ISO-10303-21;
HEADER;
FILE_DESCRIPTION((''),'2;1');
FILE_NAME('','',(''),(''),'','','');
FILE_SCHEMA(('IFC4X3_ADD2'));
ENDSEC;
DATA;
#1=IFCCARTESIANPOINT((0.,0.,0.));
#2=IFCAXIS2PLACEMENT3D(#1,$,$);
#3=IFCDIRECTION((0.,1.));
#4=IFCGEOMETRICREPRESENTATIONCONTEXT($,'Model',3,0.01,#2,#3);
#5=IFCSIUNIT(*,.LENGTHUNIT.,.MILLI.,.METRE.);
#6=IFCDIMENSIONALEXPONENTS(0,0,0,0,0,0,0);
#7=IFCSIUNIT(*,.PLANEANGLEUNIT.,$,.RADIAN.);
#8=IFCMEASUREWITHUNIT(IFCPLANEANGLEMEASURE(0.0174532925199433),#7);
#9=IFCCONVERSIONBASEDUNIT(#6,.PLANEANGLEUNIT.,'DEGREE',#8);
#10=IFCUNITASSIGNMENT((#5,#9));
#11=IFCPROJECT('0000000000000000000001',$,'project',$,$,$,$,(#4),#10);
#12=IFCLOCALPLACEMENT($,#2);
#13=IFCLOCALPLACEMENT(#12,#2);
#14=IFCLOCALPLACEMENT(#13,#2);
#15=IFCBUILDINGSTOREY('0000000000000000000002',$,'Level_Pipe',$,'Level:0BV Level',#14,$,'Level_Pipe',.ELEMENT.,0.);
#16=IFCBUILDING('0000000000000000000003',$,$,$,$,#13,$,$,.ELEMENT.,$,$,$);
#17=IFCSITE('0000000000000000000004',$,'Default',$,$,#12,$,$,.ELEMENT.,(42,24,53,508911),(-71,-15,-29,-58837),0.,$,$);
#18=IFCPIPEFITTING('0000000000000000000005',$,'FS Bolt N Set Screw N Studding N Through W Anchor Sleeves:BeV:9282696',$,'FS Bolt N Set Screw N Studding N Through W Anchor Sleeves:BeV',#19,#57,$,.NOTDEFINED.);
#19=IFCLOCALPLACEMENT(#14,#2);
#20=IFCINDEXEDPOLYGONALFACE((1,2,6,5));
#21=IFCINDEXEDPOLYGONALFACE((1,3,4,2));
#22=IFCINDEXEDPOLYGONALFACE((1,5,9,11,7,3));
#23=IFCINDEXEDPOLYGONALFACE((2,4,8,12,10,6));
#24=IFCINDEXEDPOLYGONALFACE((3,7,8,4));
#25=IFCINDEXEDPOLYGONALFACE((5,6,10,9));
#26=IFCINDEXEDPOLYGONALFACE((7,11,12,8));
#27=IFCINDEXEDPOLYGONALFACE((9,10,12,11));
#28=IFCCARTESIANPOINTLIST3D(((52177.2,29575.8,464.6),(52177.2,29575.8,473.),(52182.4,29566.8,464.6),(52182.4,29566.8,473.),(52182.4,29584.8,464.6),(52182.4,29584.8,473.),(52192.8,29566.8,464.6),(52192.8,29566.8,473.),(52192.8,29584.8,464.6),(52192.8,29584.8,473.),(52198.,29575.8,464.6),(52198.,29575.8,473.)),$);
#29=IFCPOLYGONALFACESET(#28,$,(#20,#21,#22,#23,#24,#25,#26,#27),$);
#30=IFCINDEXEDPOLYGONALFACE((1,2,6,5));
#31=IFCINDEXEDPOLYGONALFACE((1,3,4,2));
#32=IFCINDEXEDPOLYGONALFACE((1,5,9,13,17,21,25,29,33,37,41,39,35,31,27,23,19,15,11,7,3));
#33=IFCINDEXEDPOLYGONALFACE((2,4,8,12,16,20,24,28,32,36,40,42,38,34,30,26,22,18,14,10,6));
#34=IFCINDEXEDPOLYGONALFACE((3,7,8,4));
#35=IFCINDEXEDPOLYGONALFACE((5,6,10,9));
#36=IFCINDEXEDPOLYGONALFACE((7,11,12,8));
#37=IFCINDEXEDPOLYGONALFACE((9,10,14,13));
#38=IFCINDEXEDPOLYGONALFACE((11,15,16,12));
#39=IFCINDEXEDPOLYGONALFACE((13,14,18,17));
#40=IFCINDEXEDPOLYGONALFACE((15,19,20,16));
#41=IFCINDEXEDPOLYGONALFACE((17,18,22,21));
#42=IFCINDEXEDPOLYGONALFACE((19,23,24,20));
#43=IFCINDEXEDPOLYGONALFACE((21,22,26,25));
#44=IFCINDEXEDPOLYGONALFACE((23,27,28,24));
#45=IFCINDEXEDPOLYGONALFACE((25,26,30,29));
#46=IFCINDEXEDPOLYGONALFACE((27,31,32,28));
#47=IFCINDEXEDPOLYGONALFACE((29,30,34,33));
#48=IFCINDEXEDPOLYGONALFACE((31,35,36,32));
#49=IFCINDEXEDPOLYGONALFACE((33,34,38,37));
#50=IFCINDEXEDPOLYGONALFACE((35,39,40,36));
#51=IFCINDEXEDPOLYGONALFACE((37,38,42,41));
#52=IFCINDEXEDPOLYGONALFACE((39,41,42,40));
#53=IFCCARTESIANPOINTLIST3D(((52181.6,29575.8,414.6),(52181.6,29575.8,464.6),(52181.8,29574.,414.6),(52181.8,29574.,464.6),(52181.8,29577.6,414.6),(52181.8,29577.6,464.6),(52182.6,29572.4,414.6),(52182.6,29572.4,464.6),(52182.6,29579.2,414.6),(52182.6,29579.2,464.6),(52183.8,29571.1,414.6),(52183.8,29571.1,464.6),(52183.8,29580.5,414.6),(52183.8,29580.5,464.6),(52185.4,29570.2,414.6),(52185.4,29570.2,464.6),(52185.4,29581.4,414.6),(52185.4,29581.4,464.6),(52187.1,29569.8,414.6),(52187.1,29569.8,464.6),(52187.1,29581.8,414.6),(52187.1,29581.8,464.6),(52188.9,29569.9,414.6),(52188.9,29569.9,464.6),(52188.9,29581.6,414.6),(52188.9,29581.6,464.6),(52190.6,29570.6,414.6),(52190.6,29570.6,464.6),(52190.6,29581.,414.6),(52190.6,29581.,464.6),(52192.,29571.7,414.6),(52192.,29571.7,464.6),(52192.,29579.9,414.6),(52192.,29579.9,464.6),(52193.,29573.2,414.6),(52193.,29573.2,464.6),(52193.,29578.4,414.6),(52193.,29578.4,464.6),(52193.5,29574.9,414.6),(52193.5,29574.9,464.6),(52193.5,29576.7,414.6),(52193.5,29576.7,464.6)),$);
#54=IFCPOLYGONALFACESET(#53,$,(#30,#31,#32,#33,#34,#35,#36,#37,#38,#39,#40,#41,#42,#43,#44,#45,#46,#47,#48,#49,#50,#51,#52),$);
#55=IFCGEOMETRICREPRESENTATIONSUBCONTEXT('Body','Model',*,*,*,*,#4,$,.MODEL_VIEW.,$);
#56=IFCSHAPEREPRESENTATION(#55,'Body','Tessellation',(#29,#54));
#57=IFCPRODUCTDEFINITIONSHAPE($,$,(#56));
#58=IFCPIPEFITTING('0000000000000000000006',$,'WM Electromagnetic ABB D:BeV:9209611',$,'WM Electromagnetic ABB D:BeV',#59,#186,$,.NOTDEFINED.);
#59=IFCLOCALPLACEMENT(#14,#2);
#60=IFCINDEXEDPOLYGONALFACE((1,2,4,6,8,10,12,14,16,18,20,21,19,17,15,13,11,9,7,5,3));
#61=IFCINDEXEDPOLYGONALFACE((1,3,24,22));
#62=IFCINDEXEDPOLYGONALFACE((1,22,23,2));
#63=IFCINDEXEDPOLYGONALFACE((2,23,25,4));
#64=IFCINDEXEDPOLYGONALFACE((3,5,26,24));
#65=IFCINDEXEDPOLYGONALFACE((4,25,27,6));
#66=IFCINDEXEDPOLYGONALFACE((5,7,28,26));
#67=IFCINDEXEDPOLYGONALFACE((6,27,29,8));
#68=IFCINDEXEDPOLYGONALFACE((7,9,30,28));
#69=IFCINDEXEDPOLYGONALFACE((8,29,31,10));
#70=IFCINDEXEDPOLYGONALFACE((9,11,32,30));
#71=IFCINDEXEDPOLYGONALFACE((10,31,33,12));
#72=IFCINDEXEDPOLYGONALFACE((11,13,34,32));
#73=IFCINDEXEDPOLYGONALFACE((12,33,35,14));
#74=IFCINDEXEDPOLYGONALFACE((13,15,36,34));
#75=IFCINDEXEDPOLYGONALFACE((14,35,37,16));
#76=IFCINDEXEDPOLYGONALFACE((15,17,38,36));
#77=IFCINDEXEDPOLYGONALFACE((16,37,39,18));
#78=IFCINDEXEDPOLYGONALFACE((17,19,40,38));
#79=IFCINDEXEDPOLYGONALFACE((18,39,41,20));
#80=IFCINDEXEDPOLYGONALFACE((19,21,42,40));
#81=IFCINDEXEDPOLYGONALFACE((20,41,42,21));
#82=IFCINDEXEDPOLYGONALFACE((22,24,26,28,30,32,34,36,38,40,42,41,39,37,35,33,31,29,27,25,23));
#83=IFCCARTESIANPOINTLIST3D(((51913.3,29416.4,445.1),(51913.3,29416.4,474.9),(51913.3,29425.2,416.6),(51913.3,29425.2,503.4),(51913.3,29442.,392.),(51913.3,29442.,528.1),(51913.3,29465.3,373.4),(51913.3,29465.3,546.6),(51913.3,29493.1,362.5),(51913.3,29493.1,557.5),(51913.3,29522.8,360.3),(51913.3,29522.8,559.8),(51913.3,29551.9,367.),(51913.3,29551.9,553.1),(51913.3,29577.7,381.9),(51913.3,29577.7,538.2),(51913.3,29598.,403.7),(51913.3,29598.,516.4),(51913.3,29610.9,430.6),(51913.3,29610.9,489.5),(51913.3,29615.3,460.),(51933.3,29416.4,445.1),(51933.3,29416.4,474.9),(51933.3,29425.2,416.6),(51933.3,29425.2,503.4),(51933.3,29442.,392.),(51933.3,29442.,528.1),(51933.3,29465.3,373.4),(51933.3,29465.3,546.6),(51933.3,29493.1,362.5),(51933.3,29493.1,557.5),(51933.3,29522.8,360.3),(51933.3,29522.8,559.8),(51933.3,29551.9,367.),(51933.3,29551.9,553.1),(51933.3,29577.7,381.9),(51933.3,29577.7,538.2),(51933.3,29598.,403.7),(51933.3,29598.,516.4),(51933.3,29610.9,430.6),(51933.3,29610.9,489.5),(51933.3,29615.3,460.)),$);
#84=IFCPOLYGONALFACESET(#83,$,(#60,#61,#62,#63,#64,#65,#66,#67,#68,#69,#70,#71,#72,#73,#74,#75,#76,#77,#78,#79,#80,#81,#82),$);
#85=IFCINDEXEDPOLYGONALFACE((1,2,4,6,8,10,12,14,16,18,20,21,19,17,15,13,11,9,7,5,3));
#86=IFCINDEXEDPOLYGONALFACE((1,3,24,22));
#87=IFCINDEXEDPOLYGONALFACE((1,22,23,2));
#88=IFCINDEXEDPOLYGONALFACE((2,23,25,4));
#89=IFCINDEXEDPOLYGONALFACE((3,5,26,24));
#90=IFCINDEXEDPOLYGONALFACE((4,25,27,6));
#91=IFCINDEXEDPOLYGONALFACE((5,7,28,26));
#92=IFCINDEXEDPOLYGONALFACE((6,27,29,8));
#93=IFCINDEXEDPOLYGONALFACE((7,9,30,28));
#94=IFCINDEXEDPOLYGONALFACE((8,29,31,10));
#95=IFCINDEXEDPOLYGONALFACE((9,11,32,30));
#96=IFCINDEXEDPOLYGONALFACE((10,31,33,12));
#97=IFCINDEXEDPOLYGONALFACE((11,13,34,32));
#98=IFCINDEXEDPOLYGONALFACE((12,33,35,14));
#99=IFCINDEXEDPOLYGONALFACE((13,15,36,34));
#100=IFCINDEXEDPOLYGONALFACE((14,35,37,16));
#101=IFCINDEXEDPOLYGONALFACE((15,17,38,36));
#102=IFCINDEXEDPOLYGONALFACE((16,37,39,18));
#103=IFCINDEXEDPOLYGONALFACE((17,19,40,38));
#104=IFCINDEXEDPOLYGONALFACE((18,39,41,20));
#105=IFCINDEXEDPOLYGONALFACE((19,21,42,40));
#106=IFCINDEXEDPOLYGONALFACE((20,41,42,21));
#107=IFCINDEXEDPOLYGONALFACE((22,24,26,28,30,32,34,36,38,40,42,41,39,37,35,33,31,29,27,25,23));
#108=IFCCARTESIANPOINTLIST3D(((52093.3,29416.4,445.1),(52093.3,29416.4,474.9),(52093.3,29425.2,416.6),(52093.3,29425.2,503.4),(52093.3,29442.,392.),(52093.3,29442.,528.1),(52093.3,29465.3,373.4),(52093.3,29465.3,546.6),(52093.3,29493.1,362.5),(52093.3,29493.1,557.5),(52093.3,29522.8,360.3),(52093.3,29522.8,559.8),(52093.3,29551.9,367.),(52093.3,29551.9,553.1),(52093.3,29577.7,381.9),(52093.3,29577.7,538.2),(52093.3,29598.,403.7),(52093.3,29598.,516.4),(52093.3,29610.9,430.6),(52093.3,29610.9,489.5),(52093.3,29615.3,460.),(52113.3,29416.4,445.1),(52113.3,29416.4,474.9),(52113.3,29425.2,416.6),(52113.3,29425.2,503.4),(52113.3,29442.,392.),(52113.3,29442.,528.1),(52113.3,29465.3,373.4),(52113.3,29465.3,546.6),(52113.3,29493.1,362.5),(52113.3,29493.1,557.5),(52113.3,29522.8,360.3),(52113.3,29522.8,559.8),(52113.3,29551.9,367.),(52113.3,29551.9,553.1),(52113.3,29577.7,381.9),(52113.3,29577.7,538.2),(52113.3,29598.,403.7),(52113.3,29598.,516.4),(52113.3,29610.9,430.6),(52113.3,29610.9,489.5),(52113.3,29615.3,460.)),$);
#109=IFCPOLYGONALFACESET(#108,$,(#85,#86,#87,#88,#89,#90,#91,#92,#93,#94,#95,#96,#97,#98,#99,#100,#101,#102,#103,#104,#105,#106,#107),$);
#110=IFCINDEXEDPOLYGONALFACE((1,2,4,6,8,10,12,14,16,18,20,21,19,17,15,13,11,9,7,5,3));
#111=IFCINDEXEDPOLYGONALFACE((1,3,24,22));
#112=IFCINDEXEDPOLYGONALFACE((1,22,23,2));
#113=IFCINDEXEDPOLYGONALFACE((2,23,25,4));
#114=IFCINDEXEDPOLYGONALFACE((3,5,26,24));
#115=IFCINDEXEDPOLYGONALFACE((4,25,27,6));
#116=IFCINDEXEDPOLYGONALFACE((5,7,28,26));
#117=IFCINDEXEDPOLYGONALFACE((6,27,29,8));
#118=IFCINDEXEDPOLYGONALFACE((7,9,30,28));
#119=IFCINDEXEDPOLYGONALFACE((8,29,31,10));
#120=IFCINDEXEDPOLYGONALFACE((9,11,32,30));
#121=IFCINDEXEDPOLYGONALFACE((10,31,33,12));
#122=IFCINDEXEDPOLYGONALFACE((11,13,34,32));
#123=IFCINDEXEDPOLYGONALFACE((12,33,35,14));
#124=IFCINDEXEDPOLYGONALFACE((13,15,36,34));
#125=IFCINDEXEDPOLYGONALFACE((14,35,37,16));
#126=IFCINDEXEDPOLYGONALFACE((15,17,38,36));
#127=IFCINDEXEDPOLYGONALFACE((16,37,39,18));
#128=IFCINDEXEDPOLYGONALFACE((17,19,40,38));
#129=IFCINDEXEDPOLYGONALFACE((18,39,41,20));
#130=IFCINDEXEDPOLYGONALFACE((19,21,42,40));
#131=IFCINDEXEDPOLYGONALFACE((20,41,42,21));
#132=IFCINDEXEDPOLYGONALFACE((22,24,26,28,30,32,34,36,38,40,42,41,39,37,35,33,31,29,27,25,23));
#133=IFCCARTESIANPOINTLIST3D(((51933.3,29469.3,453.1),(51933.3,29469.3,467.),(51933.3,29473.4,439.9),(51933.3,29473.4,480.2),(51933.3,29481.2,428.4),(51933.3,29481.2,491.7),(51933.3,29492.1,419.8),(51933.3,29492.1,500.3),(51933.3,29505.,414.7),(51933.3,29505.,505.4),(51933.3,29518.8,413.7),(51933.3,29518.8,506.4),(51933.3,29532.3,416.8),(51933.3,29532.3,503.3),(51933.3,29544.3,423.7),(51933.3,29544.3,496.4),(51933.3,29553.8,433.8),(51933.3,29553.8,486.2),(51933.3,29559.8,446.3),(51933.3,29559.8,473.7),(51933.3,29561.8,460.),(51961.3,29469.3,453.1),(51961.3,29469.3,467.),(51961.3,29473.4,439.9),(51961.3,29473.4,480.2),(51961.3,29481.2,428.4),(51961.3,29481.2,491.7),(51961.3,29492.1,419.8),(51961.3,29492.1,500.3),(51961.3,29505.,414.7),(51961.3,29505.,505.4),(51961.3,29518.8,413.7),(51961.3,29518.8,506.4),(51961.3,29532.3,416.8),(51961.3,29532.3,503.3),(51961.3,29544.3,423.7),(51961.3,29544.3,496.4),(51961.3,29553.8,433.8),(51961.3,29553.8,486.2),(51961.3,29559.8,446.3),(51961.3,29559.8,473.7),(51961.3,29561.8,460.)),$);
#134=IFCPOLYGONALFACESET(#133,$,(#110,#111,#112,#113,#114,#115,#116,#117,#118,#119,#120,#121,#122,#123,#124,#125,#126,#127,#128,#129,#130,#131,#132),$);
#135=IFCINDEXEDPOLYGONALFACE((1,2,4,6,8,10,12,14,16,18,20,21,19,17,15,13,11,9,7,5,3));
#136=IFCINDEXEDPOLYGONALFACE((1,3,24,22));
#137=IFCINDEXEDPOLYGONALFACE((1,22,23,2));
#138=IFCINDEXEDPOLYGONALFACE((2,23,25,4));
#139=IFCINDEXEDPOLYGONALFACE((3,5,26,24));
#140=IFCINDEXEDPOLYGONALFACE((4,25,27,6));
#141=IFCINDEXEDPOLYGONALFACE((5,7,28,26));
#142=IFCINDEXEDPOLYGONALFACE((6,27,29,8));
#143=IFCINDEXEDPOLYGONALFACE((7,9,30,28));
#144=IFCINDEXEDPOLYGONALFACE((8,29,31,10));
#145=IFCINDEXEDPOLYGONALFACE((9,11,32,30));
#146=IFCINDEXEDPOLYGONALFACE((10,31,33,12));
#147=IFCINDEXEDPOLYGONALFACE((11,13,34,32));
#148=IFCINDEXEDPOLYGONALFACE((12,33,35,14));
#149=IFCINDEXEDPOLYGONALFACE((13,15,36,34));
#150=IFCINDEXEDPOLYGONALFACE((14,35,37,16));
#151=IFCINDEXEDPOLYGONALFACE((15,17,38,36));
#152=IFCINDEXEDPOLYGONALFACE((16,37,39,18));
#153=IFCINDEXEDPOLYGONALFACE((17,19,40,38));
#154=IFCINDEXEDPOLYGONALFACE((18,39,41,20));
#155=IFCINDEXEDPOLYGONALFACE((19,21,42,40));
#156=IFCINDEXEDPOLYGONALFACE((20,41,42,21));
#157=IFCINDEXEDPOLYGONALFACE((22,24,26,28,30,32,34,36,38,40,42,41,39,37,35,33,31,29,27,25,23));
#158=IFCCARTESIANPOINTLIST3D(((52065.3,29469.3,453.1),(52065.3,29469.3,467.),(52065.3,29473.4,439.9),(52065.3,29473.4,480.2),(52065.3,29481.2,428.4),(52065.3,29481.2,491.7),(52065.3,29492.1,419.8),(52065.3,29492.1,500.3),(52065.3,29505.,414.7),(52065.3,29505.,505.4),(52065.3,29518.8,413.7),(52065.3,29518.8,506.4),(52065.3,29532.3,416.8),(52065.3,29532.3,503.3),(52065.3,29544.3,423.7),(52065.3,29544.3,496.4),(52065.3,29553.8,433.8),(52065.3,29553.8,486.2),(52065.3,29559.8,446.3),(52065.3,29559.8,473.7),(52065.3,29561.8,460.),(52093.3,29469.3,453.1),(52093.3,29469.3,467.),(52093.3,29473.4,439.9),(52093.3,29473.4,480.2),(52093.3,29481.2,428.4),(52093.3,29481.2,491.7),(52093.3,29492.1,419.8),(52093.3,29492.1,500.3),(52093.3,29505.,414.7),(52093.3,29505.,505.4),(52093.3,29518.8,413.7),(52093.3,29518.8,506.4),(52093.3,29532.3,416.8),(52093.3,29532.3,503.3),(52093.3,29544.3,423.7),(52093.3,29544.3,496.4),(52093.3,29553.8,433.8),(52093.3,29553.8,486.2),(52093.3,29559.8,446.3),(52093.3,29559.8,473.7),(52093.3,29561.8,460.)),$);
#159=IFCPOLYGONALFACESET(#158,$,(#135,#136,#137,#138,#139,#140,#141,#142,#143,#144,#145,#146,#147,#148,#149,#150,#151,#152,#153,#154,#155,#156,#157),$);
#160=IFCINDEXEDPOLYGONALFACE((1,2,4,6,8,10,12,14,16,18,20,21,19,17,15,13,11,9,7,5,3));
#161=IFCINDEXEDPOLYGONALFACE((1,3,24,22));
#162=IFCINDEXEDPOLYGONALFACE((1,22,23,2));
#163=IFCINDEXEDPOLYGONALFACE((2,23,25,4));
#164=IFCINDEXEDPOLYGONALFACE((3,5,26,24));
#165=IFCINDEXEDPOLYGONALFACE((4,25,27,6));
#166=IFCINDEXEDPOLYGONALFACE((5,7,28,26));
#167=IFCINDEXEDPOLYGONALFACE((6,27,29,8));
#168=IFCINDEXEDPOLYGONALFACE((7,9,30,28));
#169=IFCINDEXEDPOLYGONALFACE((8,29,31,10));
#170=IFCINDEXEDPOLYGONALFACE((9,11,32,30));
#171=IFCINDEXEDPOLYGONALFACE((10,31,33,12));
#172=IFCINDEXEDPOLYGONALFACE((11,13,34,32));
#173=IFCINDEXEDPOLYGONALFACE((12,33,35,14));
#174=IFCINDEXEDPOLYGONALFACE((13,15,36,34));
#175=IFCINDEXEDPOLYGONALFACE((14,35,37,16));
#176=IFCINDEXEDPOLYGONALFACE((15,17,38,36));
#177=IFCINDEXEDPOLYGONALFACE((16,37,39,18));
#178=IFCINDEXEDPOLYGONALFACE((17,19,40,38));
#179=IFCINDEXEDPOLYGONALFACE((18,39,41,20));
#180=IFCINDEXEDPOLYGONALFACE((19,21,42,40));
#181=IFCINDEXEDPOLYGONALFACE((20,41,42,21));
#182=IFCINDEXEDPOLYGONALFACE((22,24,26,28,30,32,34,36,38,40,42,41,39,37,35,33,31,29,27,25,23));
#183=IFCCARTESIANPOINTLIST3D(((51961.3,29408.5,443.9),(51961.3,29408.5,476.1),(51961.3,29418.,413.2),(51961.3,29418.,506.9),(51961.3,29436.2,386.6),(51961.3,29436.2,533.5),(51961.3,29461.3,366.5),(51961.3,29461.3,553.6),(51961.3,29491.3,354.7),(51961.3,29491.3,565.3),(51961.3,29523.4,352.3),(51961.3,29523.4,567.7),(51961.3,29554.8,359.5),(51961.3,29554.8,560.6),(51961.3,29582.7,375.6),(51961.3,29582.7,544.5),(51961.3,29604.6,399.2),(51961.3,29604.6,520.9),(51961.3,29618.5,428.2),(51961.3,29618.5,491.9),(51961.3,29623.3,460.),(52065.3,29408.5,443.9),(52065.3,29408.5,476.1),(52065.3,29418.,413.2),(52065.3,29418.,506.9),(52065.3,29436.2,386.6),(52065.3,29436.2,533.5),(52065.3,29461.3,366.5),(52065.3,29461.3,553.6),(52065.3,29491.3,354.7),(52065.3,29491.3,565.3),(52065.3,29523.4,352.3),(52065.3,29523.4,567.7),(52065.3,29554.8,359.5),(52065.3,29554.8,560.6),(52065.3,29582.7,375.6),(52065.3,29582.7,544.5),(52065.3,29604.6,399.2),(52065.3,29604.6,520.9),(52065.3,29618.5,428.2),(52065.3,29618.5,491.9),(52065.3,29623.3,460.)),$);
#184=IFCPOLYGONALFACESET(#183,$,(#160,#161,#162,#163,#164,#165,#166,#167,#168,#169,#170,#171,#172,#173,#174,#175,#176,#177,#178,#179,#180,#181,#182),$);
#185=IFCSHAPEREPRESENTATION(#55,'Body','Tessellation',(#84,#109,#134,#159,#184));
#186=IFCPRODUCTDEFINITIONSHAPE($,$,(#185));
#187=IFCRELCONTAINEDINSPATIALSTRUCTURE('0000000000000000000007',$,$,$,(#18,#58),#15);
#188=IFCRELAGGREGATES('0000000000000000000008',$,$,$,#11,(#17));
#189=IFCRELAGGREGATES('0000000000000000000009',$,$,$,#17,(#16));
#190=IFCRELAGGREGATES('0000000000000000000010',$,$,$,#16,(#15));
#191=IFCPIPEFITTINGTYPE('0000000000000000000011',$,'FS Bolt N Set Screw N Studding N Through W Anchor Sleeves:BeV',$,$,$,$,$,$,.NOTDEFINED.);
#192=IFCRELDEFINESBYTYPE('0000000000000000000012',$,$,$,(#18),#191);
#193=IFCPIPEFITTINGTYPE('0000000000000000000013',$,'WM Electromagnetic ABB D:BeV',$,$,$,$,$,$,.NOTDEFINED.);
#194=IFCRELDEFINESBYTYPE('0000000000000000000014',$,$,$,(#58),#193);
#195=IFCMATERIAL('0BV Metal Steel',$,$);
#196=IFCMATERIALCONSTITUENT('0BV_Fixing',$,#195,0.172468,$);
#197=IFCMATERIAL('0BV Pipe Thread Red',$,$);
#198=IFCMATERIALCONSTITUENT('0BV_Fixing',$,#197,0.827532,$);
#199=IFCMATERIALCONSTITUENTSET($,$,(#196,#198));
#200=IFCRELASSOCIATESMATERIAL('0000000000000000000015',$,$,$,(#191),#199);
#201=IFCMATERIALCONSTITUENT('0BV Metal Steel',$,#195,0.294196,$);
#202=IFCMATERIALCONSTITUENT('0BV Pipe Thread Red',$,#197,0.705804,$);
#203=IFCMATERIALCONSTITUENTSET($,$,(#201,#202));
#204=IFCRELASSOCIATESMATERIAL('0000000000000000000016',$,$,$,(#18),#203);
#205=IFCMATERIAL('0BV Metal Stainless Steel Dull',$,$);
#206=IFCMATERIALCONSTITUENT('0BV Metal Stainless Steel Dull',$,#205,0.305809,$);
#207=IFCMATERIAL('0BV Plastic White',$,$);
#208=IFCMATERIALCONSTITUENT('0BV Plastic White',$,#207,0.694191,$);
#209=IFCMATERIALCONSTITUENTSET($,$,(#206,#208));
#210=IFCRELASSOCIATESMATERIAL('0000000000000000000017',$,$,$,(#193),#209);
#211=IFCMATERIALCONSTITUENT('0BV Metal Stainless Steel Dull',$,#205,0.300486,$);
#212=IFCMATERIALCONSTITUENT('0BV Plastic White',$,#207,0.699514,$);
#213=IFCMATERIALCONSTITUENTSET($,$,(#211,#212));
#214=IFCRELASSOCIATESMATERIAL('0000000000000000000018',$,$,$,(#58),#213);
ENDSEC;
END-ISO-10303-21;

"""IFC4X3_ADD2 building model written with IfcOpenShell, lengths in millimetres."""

from ifc_helpers import new_model, entity, si_unit, converted_unit, direction, frame, frame_2d, origin, place, context, subcontext, project, spatial, polyline, circle, outline, extrude, source, transform, mapped, material, constituent, constituent_set, type_object, type_shapes, element, save


model = new_model("IFC4X3_ADD2")

# Units and contexts
model_context = context("Model", 3, precision=0.01, world=origin(), true_north=direction((0.0, 1.0)))
body_context = subcontext(model_context, "Body", "Model", "MODEL_VIEW")
ifc_project = project(units=[si_unit("LENGTHUNIT", "METRE", prefix="MILLI"), converted_unit("PLANEANGLEUNIT", "DEGREE", entity("IfcPlaneAngleMeasure", 0.0174532925199433), si_unit("PLANEANGLEUNIT", "RADIAN"), dimensions=[0, 0, 0, 0, 0, 0, 0])], contexts=[model_context])

# Site, building, storey
site_placement = place(None, origin())
site = spatial("IfcSite", under=ifc_project, at=site_placement, Name="Default", CompositionType="ELEMENT", RefLatitude=(42, 24, 53, 508911), RefLongitude=(-71, -15, -29, -58837), RefElevation=0.0)
building_placement = place(site_placement, origin())
building = spatial("IfcBuilding", under=site, at=building_placement, CompositionType="ELEMENT")
storey_placement = place(building_placement, origin())
storey = spatial("IfcBuildingStorey", under=building, at=storey_placement, Name="Level_Pipe", ObjectType="Level:0BV Level", LongName="Level_Pipe", CompositionType="ELEMENT", Elevation=0.0)

# Pipe fitting
ifc_material_1 = material(Name="0BV Metal Stainless Steel Dull")
ifc_material_2 = material(Name="0BV Metal Steel")
ifc_material_3 = material(Name="0BV Pipe Thread Red")
ifc_constituent_1 = constituent(ifc_material_2, Name="0BV_Fixing", fraction=0.172468)
ifc_constituent_2 = constituent(ifc_material_3, Name="0BV_Fixing", fraction=0.827532)
ifc_constituent_set_1 = constituent_set(constituents=[ifc_constituent_1, ifc_constituent_2])
pipe_fitting_type_1 = type_object("IfcPipeFittingType", Name="FS Bolt N Set Screw N Studding N Through W Anchor Sleeves:BeV", PredefinedType="NOTDEFINED", material=ifc_constituent_set_1)
shared_shape_1 = source(origin(), body_context, "Body", "SweptSolid", [
    extrude(outline(polyline([(-5.2, -9.0), (5.2, -9.0), (10.4, 0.0), (5.2, 9.0), (-5.2, 9.0), (-10.4, 0.0), (-5.2, -9.0)])), frame((-8.4, 0.0, 0.0), z_axis=(1.0, 0.0, 0.0), x_axis=(0.0, -1.0, 0.0)), (0.0, 0.0, 1.0), 8.4),
    extrude(circle(Radius=6.0, at=frame_2d((0.0, 0.0), x_axis=(1.0, 0.0))), frame((0.0, 0.0, 0.0), z_axis=(1.0, 0.0, 0.0), x_axis=(0.0, -1.0, 0.0)), (0.0, 0.0, 1.0), 50.0),
])
type_shapes(pipe_fitting_type_1, [shared_shape_1])
ifc_constituent_3 = constituent(ifc_material_2, Name="0BV Metal Steel", fraction=0.294196)
ifc_constituent_4 = constituent(ifc_material_3, Name="0BV Pipe Thread Red", fraction=0.705804)
ifc_constituent_set_2 = constituent_set(constituents=[ifc_constituent_3, ifc_constituent_4])
pipe_fitting_1_placement = place(storey_placement, frame((52187.6, 29575.8, 464.6), z_axis=(0.0, -1.0, 0.0), x_axis=(0.0, 0.0, -1.0)))
element("IfcPipeFitting", 1, at=pipe_fitting_1_placement, inside=storey, type_object=pipe_fitting_type_1, material=ifc_constituent_set_2, Name="FS Bolt N Set Screw N Studding N Through W Anchor Sleeves:BeV:9282696", ObjectType="FS Bolt N Set Screw N Studding N Through W Anchor Sleeves:BeV", PredefinedType="NOTDEFINED", context=body_context, shape_type="MappedRepresentation", body=[
    mapped(shared_shape_1, transform((0.0, 0.0, 0.0), scale=1.0)),
])

# Pipe fitting
ifc_constituent_5 = constituent(ifc_material_1, Name="0BV Metal Stainless Steel Dull", fraction=0.300486)
ifc_material_4 = material(Name="0BV Plastic White")
ifc_constituent_6 = constituent(ifc_material_4, Name="0BV Plastic White", fraction=0.699514)
ifc_constituent_set_3 = constituent_set(constituents=[ifc_constituent_5, ifc_constituent_6])
ifc_constituent_7 = constituent(ifc_material_1, Name="0BV Metal Stainless Steel Dull", fraction=0.305809)
ifc_constituent_8 = constituent(ifc_material_4, Name="0BV Plastic White", fraction=0.694191)
ifc_constituent_set_4 = constituent_set(constituents=[ifc_constituent_7, ifc_constituent_8])
pipe_fitting_type_2 = type_object("IfcPipeFittingType", Name="WM Electromagnetic ABB D:BeV", PredefinedType="NOTDEFINED", material=ifc_constituent_set_4)
shared_shape_2 = source(origin(), body_context, "Body", "SweptSolid", [
    extrude(circle(Radius=100.0, at=frame_2d((0.0, 0.0), x_axis=(1.0, 0.0))), frame((-100.0, 0.0, 0.0), z_axis=(1.0, 0.0, 0.0), x_axis=(0.0, 1.0, 0.0)), (0.0, 0.0, 1.0), 20.0),
    extrude(circle(Radius=100.0, at=frame_2d((0.0, 0.0), x_axis=(1.0, 0.0))), frame((80.0, 0.0, 0.0), z_axis=(1.0, 0.0, 0.0), x_axis=(0.0, 1.0, 0.0)), (0.0, 0.0, 1.0), 20.0),
    extrude(circle(Radius=46.5, at=frame_2d((0.0, 0.0), x_axis=(1.0, 0.0))), frame((-80.0, 0.0, 0.0), z_axis=(1.0, 0.0, 0.0), x_axis=(0.0, 1.0, 0.0)), (0.0, 0.0, 1.0), 28.0),
    extrude(circle(Radius=46.5, at=frame_2d((0.0, 0.0), x_axis=(1.0, 0.0))), frame((52.0, 0.0, 0.0), z_axis=(1.0, 0.0, 0.0), x_axis=(0.0, 1.0, 0.0)), (0.0, 0.0, 1.0), 28.0),
    extrude(circle(Radius=108.0, at=frame_2d((0.0, 0.0), x_axis=(1.0, 0.0))), frame((-52.0, 0.0, 0.0), z_axis=(1.0, 0.0, 0.0), x_axis=(0.0, 1.0, 0.0)), (0.0, 0.0, 1.0), 104.0),
])
type_shapes(pipe_fitting_type_2, [shared_shape_2])
pipe_fitting_2_placement = place(storey_placement, frame((52013.3, 29515.3, 460.0)))
element("IfcPipeFitting", 2, at=pipe_fitting_2_placement, inside=storey, type_object=pipe_fitting_type_2, material=ifc_constituent_set_3, Name="WM Electromagnetic ABB D:BeV:9209611", ObjectType="WM Electromagnetic ABB D:BeV", PredefinedType="NOTDEFINED", context=body_context, shape_type="MappedRepresentation", body=[
    mapped(shared_shape_2, transform((0.0, 0.0, 0.0), scale=1.0)),
])

save(model, "model.ifc")
